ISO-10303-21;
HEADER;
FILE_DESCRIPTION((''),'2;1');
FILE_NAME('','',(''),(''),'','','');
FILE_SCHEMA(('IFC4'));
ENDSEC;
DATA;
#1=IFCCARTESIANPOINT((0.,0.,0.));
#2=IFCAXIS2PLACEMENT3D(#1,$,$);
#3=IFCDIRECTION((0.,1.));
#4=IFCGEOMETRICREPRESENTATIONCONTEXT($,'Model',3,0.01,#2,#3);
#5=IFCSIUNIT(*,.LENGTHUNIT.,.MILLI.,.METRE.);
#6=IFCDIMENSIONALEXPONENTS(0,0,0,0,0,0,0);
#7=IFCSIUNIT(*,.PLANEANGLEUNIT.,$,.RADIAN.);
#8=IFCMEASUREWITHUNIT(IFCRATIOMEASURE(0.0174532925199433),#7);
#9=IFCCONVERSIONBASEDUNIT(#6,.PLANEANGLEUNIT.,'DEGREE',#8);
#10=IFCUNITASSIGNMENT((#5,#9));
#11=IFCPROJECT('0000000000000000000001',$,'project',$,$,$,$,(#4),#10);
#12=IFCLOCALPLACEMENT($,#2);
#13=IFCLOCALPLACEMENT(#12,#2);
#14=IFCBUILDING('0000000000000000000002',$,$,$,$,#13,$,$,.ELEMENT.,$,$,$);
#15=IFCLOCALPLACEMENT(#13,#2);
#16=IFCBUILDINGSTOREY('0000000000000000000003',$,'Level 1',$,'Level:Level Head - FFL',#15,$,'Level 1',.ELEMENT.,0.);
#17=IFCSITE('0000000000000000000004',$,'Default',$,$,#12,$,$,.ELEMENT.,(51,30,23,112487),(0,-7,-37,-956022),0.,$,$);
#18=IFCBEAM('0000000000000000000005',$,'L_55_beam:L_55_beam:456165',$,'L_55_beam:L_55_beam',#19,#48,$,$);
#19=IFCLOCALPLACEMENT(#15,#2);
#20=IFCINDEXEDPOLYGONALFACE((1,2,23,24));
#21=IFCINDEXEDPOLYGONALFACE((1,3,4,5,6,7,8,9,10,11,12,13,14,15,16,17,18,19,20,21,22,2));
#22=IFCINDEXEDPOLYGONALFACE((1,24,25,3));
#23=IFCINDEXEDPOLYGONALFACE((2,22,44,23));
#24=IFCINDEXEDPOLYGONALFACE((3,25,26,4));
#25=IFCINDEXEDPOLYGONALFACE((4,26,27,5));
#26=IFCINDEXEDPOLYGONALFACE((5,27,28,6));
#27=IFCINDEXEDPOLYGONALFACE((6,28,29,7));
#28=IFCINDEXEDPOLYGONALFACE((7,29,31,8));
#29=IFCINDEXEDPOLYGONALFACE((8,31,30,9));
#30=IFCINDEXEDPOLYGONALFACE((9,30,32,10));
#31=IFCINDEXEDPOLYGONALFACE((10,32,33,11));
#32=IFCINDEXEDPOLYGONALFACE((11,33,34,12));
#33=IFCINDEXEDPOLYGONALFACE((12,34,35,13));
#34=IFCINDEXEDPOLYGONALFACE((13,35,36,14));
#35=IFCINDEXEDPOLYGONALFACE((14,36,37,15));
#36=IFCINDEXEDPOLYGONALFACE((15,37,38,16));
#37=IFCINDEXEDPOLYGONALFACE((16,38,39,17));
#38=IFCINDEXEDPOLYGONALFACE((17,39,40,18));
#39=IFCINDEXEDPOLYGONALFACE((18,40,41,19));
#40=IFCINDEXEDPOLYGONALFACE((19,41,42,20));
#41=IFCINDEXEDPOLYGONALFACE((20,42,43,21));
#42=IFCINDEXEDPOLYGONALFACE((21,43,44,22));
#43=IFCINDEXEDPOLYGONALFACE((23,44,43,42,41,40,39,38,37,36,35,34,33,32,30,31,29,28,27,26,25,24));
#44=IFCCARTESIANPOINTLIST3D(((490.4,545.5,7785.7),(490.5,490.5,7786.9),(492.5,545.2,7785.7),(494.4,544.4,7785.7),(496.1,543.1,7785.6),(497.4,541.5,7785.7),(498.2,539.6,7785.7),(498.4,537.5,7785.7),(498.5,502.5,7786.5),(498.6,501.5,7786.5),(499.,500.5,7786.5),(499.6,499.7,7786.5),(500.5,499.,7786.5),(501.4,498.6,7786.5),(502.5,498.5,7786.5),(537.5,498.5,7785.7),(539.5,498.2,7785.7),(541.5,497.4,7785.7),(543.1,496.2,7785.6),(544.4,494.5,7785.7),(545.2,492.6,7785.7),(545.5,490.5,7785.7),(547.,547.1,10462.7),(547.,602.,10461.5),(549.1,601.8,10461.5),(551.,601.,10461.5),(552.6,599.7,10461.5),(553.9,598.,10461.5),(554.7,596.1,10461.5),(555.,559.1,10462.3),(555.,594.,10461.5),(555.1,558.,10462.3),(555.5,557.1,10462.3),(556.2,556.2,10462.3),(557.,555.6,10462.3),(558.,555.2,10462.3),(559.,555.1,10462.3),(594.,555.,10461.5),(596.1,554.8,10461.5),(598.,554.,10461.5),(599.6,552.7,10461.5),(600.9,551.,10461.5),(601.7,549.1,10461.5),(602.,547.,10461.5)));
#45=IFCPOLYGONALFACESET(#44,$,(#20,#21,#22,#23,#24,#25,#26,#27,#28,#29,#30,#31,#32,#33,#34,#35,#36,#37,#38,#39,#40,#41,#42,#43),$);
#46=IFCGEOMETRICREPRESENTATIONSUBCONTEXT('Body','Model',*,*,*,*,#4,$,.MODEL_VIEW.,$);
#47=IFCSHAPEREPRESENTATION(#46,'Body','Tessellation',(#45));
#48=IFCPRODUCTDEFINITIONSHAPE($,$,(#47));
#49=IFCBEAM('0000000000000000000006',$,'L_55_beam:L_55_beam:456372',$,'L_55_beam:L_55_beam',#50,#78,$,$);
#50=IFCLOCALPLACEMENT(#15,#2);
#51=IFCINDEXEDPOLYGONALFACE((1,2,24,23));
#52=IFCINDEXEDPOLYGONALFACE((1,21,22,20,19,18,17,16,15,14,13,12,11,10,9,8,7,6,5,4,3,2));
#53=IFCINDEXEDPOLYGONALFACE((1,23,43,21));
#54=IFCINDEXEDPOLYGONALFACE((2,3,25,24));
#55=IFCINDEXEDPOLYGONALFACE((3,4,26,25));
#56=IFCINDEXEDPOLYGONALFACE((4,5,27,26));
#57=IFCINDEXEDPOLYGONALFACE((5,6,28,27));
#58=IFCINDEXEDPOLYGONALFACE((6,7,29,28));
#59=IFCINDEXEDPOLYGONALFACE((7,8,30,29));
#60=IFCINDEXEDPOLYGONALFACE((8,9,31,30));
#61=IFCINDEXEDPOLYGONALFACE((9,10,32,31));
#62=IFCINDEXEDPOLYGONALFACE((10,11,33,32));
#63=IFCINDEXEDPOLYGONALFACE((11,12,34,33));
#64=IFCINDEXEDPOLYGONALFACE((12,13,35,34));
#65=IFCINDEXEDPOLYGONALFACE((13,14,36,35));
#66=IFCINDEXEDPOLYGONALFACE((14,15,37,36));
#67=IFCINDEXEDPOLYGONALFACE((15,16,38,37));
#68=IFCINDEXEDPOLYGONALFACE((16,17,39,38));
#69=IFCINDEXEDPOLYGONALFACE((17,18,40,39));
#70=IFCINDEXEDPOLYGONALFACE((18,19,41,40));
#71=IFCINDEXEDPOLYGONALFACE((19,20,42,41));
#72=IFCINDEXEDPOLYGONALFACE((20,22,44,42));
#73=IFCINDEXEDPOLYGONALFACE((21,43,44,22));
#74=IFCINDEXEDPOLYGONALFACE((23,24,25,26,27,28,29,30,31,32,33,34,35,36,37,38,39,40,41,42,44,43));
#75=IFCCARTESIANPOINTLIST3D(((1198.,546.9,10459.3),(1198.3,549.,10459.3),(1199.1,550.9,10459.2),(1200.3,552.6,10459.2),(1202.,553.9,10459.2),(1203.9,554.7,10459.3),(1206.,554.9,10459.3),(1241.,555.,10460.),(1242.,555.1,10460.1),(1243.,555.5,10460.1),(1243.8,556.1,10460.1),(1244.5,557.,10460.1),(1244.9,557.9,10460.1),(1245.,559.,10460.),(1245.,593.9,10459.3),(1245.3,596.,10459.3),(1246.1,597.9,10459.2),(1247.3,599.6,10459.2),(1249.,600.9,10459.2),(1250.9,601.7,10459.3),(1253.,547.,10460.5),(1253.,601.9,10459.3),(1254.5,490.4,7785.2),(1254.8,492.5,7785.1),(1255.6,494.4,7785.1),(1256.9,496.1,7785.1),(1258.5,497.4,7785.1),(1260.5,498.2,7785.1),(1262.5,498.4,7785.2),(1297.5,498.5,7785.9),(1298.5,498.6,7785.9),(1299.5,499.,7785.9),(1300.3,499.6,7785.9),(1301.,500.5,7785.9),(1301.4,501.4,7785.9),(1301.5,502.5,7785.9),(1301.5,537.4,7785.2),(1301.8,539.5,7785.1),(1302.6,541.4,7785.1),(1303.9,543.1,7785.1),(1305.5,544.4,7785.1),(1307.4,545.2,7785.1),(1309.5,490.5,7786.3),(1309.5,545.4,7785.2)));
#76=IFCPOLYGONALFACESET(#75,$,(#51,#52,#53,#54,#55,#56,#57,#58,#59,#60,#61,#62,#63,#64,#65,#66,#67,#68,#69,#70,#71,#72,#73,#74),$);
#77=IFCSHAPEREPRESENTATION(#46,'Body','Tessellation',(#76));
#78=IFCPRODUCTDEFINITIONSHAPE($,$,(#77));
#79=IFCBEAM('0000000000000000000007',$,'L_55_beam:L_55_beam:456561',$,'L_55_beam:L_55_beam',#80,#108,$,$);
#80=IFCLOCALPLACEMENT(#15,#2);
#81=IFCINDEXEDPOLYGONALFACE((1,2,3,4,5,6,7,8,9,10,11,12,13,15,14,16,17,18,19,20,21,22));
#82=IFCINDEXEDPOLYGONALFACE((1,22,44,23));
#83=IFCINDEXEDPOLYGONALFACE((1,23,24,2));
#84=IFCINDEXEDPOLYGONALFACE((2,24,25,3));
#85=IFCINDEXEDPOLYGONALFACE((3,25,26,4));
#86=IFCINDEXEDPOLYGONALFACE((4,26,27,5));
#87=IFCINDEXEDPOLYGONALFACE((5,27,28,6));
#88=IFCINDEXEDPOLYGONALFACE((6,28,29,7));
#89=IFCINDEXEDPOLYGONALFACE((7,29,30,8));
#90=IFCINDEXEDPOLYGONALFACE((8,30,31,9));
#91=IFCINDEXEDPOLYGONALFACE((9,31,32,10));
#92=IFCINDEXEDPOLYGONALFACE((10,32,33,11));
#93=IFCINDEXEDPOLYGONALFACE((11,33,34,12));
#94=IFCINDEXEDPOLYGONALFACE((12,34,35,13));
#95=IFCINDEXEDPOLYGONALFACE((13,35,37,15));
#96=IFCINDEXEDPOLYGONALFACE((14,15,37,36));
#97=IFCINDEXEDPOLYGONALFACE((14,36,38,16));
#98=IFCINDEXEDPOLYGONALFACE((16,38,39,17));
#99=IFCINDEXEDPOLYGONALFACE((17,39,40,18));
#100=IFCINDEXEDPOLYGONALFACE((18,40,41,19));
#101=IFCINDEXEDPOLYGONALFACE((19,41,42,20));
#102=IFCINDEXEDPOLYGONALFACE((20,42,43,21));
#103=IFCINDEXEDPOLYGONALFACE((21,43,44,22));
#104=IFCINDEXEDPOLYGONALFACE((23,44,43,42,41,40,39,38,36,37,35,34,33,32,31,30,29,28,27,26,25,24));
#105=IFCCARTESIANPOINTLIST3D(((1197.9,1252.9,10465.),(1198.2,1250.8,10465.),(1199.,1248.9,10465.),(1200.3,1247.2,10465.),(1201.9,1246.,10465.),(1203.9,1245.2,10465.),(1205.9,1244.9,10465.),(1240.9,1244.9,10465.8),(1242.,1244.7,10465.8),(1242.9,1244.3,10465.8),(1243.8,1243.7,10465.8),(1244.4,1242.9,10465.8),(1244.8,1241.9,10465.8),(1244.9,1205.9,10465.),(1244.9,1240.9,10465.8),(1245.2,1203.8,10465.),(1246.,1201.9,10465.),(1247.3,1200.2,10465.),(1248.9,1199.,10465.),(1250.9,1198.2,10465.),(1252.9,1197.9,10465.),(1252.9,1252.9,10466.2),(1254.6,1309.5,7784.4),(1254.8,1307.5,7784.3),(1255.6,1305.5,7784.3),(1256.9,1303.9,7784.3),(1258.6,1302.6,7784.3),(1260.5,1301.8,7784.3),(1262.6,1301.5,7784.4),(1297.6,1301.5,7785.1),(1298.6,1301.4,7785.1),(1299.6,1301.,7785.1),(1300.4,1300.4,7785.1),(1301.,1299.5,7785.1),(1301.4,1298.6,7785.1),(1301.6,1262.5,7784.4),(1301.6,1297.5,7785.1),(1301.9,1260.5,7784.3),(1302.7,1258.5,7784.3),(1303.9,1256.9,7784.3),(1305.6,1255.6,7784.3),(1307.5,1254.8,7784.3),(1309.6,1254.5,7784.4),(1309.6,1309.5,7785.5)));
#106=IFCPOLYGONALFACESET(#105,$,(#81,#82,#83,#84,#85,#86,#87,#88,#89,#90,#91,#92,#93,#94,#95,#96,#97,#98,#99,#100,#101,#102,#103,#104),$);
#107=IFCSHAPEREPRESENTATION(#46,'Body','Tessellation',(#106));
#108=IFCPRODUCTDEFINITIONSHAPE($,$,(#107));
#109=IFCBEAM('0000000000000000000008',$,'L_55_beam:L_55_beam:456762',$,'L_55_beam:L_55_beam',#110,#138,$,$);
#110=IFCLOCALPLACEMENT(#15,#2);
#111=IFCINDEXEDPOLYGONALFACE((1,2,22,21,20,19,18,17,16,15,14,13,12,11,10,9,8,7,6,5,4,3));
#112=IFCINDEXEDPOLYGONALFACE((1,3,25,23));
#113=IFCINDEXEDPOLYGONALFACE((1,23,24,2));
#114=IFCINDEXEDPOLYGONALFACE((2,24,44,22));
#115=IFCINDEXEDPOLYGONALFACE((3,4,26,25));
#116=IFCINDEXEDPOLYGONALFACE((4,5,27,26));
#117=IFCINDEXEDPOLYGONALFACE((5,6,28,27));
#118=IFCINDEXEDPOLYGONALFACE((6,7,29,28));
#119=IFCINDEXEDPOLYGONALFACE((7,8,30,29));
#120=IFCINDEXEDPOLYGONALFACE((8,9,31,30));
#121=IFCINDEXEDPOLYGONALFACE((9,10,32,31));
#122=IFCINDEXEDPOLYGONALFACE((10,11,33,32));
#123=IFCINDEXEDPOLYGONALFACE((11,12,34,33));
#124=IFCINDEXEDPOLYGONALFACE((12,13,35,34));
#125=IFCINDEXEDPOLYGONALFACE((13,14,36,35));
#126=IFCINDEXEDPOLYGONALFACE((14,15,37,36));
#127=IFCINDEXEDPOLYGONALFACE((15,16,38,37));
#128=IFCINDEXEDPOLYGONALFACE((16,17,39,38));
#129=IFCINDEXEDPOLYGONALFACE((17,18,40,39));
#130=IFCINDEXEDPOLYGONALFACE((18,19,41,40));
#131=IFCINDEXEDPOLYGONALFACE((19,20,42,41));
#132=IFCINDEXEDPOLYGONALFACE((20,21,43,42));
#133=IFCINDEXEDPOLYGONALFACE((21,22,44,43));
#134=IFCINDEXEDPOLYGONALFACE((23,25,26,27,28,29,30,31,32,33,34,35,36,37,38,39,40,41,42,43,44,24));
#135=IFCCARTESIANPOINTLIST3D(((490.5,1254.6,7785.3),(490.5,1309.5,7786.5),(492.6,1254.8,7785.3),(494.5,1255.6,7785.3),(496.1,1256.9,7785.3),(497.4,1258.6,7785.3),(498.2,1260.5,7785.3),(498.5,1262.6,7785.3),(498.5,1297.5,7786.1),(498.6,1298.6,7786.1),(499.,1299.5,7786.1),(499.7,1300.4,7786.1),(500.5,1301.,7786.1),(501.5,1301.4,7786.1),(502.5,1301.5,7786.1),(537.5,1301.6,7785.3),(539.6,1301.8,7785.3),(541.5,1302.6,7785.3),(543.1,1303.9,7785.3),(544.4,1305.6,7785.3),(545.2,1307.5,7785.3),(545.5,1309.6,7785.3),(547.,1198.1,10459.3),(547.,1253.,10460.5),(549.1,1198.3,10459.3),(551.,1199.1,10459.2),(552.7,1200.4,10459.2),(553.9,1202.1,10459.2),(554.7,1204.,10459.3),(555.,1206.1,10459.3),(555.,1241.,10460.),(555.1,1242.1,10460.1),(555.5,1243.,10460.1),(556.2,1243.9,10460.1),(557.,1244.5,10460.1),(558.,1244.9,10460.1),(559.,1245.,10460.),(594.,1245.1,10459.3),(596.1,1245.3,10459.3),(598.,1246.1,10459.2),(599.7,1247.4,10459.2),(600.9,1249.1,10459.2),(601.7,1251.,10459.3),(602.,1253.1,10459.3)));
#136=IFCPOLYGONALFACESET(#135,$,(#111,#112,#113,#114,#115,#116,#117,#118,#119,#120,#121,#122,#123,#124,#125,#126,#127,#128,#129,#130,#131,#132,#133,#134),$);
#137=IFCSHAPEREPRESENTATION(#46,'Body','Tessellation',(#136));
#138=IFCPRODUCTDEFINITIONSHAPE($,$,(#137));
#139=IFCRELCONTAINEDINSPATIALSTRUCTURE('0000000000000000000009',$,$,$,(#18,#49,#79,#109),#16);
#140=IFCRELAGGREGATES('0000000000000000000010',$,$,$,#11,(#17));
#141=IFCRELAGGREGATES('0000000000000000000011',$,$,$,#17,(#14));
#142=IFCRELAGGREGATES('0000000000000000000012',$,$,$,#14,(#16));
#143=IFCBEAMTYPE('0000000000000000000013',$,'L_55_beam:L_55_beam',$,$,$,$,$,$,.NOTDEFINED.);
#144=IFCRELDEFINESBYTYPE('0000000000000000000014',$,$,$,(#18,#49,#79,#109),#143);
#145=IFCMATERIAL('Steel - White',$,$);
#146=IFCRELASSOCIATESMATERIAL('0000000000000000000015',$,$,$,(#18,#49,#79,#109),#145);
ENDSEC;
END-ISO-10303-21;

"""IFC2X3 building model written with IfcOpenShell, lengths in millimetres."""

from ifc_helpers import new_model, entity, si_unit, converted_unit, direction, frame, frame_2d, origin, place, context, subcontext, project, spatial, polyline, circle_curve, parameter, trimmed, segment, composite_curve, outline, extrude, material, type_object, element, save


model = new_model("IFC2X3")

# Units and contexts
model_context = context("Model", 3, precision=0.01, world=origin(), true_north=direction((0.0, 1.0)))
body_context = subcontext(model_context, "Body", "Model", "MODEL_VIEW")
ifc_project = project(units=[si_unit("LENGTHUNIT", "METRE", prefix="MILLI"), converted_unit("PLANEANGLEUNIT", "DEGREE", entity("IfcRatioMeasure", 0.0174532925199433), si_unit("PLANEANGLEUNIT", "RADIAN"), dimensions=[0, 0, 0, 0, 0, 0, 0])], contexts=[model_context])

# Site, building, storey
site_placement = place(None, origin())
site = spatial("IfcSite", under=ifc_project, at=site_placement, Name="Default", CompositionType="ELEMENT", RefLatitude=(51, 30, 23, 112487), RefLongitude=(0, -7, -37, -956022), RefElevation=0.0)
building_placement = place(site_placement, origin())
building = spatial("IfcBuilding", under=site, at=building_placement, CompositionType="ELEMENT")
storey_placement = place(building_placement, origin())
storey = spatial("IfcBuildingStorey", under=building, at=storey_placement, Name="Level 1", ObjectType="Level:Level Head - FFL", LongName="Level 1", CompositionType="ELEMENT", Elevation=0.0)

# Beams
beam_type_1 = type_object("IfcBeamType", Name="L_55_beam:L_55_beam", PredefinedType="NOTDEFINED")
ifc_material_1 = material(Name="Steel - White")
beam_1_placement = place(storey_placement, frame((547.2, 547.2, 10469.7), z_axis=(0.999777, -0.000446, -0.021115), x_axis=(-0.02112, -0.021125, -0.999554)))
element("IfcBeam", 1, at=beam_1_placement, inside=storey, type_object=beam_type_1, material=ifc_material_1, Name="L_55_beam:L_55_beam:456165", ObjectType="L_55_beam:L_55_beam", context=body_context, shape_type="SweptSolid", body=[
    extrude(outline(composite_curve([segment(polyline([(-6.6, 10.6), (28.4, 10.6)]), True, "CONTINUOUS"), segment(trimmed(circle_curve(frame_2d((28.4, 18.6), x_axis=(0.0, -1.0)), 8.0), [parameter(0.0)], [parameter(90.0)], True, "PARAMETER"), True, "CONTINUOUS"), segment(polyline([(36.4, 18.6), (-18.6, 18.6)]), True, "CONTINUOUS"), segment(polyline([(-18.6, 18.6), (-18.6, -36.4)]), True, "CONTINUOUS"), segment(trimmed(circle_curve(frame_2d((-18.6, -28.4), x_axis=(0.0, -1.0)), 8.0), [parameter(0.0)], [parameter(90.0)], True, "PARAMETER"), True, "CONTINUOUS"), segment(polyline([(-10.6, -28.4), (-10.6, 6.6)]), True, "CONTINUOUS"), segment(trimmed(circle_curve(frame_2d((-6.6, 6.6), x_axis=(-1.0, 0.0)), 4.0), [parameter(270.0)], [parameter(0.0)], True, "PARAMETER"), False, "CONTINUOUS")], self_intersect=False)), frame((7.0, 18.6, 18.6), z_axis=(1.0, 0.0, 0.0), x_axis=(0.0, 0.000332, 1.0)), (0.0, 0.0, 1.0), 2677.0),
])
beam_2_placement = place(storey_placement, frame((1252.9, 547.1, 10467.1), z_axis=(0.999777, 0.000446, 0.02112), x_axis=(0.021125, -0.02112, -0.999554)))
element("IfcBeam", 2, at=beam_2_placement, inside=storey, type_object=beam_type_1, material=ifc_material_1, Name="L_55_beam:L_55_beam:456372", ObjectType="L_55_beam:L_55_beam", context=body_context, shape_type="SweptSolid", body=[
    extrude(outline(composite_curve([segment(polyline([(-36.4, -18.6), (18.6, -18.6)]), True, "CONTINUOUS"), segment(polyline([(18.6, -18.6), (18.6, 36.4)]), True, "CONTINUOUS"), segment(trimmed(circle_curve(frame_2d((18.6, 28.4), x_axis=(0.0, 1.0)), 8.0), [parameter(0.0)], [parameter(90.0)], True, "PARAMETER"), True, "CONTINUOUS"), segment(polyline([(10.6, 28.4), (10.6, -6.6)]), True, "CONTINUOUS"), segment(trimmed(circle_curve(frame_2d((6.6, -6.6), x_axis=(1.0, 0.0)), 4.0), [parameter(270.0)], [parameter(0.0)], True, "PARAMETER"), False, "CONTINUOUS"), segment(polyline([(6.6, -10.6), (-28.4, -10.6)]), True, "CONTINUOUS"), segment(trimmed(circle_curve(frame_2d((-28.4, -18.6), x_axis=(0.0, 1.0)), 8.0), [parameter(0.0)], [parameter(90.0)], True, "PARAMETER"), True, "CONTINUOUS")], self_intersect=False)), frame((6.6, 18.6, -18.6), z_axis=(1.0, 0.0, 0.0), x_axis=(0.0, -1.0, -0.000112)), (0.0, 0.0, 1.0), 2675.3),
])
beam_3_placement = place(storey_placement, frame((1252.9, 1252.9, 10466.2), z_axis=(0.999777, -0.000446, 0.021115), x_axis=(0.02112, 0.021125, -0.999554)))
element("IfcBeam", 3, at=beam_3_placement, inside=storey, type_object=beam_type_1, material=ifc_material_1, Name="L_55_beam:L_55_beam:456561", ObjectType="L_55_beam:L_55_beam", context=body_context, shape_type="SweptSolid", body=[
    extrude(outline(composite_curve([segment(polyline([(-36.4, -18.6), (18.6, -18.6)]), True, "CONTINUOUS"), segment(polyline([(18.6, -18.6), (18.6, 36.4)]), True, "CONTINUOUS"), segment(trimmed(circle_curve(frame_2d((18.6, 28.4), x_axis=(0.0, 1.0)), 8.0), [parameter(0.0)], [parameter(90.0)], True, "PARAMETER"), True, "CONTINUOUS"), segment(polyline([(10.6, 28.4), (10.6, -6.6)]), True, "CONTINUOUS"), segment(trimmed(circle_curve(frame_2d((6.6, -6.6), x_axis=(1.0, 0.0)), 4.0), [parameter(270.0)], [parameter(0.0)], True, "PARAMETER"), False, "CONTINUOUS"), segment(polyline([(6.6, -10.6), (-28.4, -10.6)]), True, "CONTINUOUS"), segment(trimmed(circle_curve(frame_2d((-28.4, -18.6), x_axis=(0.0, 1.0)), 8.0), [parameter(0.0)], [parameter(90.0)], True, "PARAMETER"), True, "CONTINUOUS")], self_intersect=False)), frame((0.0, -18.6, -18.6), z_axis=(1.0, 0.0, 0.0), x_axis=(0.0, 0.000332, 1.0)), (0.0, 0.0, 1.0), 2681.9),
])
beam_4_placement = place(storey_placement, frame((547.1, 1252.9, 10466.7), z_axis=(0.999777, 0.000446, -0.02112), x_axis=(-0.021125, 0.02112, -0.999554)))
element("IfcBeam", 4, at=beam_4_placement, inside=storey, type_object=beam_type_1, material=ifc_material_1, Name="L_55_beam:L_55_beam:456762", ObjectType="L_55_beam:L_55_beam", context=body_context, shape_type="SweptSolid", body=[
    extrude(outline(composite_curve([segment(polyline([(-18.6, -18.6), (36.4, -18.6)]), True, "CONTINUOUS"), segment(trimmed(circle_curve(frame_2d((28.4, -18.6), x_axis=(1.0, 0.0)), 8.0), [parameter(0.0)], [parameter(90.0)], True, "PARAMETER"), True, "CONTINUOUS"), segment(polyline([(28.4, -10.6), (-6.6, -10.6)]), True, "CONTINUOUS"), segment(trimmed(circle_curve(frame_2d((-6.6, -6.6), x_axis=(0.0, -1.0)), 4.0), [parameter(270.0)], [parameter(0.0)], True, "PARAMETER"), False, "CONTINUOUS"), segment(polyline([(-10.6, -6.6), (-10.6, 28.4)]), True, "CONTINUOUS"), segment(trimmed(circle_curve(frame_2d((-18.6, 28.4), x_axis=(1.0, 0.0)), 8.0), [parameter(0.0)], [parameter(90.0)], True, "PARAMETER"), True, "CONTINUOUS"), segment(polyline([(-18.6, 36.4), (-18.6, -18.6)]), True, "CONTINUOUS")], self_intersect=False)), frame((6.3, -18.6, 18.6), z_axis=(1.0, 0.0, 0.0), x_axis=(0.0, -0.000112, 1.0)), (0.0, 0.0, 1.0), 2675.1),
])

save(model, "model.ifc")
